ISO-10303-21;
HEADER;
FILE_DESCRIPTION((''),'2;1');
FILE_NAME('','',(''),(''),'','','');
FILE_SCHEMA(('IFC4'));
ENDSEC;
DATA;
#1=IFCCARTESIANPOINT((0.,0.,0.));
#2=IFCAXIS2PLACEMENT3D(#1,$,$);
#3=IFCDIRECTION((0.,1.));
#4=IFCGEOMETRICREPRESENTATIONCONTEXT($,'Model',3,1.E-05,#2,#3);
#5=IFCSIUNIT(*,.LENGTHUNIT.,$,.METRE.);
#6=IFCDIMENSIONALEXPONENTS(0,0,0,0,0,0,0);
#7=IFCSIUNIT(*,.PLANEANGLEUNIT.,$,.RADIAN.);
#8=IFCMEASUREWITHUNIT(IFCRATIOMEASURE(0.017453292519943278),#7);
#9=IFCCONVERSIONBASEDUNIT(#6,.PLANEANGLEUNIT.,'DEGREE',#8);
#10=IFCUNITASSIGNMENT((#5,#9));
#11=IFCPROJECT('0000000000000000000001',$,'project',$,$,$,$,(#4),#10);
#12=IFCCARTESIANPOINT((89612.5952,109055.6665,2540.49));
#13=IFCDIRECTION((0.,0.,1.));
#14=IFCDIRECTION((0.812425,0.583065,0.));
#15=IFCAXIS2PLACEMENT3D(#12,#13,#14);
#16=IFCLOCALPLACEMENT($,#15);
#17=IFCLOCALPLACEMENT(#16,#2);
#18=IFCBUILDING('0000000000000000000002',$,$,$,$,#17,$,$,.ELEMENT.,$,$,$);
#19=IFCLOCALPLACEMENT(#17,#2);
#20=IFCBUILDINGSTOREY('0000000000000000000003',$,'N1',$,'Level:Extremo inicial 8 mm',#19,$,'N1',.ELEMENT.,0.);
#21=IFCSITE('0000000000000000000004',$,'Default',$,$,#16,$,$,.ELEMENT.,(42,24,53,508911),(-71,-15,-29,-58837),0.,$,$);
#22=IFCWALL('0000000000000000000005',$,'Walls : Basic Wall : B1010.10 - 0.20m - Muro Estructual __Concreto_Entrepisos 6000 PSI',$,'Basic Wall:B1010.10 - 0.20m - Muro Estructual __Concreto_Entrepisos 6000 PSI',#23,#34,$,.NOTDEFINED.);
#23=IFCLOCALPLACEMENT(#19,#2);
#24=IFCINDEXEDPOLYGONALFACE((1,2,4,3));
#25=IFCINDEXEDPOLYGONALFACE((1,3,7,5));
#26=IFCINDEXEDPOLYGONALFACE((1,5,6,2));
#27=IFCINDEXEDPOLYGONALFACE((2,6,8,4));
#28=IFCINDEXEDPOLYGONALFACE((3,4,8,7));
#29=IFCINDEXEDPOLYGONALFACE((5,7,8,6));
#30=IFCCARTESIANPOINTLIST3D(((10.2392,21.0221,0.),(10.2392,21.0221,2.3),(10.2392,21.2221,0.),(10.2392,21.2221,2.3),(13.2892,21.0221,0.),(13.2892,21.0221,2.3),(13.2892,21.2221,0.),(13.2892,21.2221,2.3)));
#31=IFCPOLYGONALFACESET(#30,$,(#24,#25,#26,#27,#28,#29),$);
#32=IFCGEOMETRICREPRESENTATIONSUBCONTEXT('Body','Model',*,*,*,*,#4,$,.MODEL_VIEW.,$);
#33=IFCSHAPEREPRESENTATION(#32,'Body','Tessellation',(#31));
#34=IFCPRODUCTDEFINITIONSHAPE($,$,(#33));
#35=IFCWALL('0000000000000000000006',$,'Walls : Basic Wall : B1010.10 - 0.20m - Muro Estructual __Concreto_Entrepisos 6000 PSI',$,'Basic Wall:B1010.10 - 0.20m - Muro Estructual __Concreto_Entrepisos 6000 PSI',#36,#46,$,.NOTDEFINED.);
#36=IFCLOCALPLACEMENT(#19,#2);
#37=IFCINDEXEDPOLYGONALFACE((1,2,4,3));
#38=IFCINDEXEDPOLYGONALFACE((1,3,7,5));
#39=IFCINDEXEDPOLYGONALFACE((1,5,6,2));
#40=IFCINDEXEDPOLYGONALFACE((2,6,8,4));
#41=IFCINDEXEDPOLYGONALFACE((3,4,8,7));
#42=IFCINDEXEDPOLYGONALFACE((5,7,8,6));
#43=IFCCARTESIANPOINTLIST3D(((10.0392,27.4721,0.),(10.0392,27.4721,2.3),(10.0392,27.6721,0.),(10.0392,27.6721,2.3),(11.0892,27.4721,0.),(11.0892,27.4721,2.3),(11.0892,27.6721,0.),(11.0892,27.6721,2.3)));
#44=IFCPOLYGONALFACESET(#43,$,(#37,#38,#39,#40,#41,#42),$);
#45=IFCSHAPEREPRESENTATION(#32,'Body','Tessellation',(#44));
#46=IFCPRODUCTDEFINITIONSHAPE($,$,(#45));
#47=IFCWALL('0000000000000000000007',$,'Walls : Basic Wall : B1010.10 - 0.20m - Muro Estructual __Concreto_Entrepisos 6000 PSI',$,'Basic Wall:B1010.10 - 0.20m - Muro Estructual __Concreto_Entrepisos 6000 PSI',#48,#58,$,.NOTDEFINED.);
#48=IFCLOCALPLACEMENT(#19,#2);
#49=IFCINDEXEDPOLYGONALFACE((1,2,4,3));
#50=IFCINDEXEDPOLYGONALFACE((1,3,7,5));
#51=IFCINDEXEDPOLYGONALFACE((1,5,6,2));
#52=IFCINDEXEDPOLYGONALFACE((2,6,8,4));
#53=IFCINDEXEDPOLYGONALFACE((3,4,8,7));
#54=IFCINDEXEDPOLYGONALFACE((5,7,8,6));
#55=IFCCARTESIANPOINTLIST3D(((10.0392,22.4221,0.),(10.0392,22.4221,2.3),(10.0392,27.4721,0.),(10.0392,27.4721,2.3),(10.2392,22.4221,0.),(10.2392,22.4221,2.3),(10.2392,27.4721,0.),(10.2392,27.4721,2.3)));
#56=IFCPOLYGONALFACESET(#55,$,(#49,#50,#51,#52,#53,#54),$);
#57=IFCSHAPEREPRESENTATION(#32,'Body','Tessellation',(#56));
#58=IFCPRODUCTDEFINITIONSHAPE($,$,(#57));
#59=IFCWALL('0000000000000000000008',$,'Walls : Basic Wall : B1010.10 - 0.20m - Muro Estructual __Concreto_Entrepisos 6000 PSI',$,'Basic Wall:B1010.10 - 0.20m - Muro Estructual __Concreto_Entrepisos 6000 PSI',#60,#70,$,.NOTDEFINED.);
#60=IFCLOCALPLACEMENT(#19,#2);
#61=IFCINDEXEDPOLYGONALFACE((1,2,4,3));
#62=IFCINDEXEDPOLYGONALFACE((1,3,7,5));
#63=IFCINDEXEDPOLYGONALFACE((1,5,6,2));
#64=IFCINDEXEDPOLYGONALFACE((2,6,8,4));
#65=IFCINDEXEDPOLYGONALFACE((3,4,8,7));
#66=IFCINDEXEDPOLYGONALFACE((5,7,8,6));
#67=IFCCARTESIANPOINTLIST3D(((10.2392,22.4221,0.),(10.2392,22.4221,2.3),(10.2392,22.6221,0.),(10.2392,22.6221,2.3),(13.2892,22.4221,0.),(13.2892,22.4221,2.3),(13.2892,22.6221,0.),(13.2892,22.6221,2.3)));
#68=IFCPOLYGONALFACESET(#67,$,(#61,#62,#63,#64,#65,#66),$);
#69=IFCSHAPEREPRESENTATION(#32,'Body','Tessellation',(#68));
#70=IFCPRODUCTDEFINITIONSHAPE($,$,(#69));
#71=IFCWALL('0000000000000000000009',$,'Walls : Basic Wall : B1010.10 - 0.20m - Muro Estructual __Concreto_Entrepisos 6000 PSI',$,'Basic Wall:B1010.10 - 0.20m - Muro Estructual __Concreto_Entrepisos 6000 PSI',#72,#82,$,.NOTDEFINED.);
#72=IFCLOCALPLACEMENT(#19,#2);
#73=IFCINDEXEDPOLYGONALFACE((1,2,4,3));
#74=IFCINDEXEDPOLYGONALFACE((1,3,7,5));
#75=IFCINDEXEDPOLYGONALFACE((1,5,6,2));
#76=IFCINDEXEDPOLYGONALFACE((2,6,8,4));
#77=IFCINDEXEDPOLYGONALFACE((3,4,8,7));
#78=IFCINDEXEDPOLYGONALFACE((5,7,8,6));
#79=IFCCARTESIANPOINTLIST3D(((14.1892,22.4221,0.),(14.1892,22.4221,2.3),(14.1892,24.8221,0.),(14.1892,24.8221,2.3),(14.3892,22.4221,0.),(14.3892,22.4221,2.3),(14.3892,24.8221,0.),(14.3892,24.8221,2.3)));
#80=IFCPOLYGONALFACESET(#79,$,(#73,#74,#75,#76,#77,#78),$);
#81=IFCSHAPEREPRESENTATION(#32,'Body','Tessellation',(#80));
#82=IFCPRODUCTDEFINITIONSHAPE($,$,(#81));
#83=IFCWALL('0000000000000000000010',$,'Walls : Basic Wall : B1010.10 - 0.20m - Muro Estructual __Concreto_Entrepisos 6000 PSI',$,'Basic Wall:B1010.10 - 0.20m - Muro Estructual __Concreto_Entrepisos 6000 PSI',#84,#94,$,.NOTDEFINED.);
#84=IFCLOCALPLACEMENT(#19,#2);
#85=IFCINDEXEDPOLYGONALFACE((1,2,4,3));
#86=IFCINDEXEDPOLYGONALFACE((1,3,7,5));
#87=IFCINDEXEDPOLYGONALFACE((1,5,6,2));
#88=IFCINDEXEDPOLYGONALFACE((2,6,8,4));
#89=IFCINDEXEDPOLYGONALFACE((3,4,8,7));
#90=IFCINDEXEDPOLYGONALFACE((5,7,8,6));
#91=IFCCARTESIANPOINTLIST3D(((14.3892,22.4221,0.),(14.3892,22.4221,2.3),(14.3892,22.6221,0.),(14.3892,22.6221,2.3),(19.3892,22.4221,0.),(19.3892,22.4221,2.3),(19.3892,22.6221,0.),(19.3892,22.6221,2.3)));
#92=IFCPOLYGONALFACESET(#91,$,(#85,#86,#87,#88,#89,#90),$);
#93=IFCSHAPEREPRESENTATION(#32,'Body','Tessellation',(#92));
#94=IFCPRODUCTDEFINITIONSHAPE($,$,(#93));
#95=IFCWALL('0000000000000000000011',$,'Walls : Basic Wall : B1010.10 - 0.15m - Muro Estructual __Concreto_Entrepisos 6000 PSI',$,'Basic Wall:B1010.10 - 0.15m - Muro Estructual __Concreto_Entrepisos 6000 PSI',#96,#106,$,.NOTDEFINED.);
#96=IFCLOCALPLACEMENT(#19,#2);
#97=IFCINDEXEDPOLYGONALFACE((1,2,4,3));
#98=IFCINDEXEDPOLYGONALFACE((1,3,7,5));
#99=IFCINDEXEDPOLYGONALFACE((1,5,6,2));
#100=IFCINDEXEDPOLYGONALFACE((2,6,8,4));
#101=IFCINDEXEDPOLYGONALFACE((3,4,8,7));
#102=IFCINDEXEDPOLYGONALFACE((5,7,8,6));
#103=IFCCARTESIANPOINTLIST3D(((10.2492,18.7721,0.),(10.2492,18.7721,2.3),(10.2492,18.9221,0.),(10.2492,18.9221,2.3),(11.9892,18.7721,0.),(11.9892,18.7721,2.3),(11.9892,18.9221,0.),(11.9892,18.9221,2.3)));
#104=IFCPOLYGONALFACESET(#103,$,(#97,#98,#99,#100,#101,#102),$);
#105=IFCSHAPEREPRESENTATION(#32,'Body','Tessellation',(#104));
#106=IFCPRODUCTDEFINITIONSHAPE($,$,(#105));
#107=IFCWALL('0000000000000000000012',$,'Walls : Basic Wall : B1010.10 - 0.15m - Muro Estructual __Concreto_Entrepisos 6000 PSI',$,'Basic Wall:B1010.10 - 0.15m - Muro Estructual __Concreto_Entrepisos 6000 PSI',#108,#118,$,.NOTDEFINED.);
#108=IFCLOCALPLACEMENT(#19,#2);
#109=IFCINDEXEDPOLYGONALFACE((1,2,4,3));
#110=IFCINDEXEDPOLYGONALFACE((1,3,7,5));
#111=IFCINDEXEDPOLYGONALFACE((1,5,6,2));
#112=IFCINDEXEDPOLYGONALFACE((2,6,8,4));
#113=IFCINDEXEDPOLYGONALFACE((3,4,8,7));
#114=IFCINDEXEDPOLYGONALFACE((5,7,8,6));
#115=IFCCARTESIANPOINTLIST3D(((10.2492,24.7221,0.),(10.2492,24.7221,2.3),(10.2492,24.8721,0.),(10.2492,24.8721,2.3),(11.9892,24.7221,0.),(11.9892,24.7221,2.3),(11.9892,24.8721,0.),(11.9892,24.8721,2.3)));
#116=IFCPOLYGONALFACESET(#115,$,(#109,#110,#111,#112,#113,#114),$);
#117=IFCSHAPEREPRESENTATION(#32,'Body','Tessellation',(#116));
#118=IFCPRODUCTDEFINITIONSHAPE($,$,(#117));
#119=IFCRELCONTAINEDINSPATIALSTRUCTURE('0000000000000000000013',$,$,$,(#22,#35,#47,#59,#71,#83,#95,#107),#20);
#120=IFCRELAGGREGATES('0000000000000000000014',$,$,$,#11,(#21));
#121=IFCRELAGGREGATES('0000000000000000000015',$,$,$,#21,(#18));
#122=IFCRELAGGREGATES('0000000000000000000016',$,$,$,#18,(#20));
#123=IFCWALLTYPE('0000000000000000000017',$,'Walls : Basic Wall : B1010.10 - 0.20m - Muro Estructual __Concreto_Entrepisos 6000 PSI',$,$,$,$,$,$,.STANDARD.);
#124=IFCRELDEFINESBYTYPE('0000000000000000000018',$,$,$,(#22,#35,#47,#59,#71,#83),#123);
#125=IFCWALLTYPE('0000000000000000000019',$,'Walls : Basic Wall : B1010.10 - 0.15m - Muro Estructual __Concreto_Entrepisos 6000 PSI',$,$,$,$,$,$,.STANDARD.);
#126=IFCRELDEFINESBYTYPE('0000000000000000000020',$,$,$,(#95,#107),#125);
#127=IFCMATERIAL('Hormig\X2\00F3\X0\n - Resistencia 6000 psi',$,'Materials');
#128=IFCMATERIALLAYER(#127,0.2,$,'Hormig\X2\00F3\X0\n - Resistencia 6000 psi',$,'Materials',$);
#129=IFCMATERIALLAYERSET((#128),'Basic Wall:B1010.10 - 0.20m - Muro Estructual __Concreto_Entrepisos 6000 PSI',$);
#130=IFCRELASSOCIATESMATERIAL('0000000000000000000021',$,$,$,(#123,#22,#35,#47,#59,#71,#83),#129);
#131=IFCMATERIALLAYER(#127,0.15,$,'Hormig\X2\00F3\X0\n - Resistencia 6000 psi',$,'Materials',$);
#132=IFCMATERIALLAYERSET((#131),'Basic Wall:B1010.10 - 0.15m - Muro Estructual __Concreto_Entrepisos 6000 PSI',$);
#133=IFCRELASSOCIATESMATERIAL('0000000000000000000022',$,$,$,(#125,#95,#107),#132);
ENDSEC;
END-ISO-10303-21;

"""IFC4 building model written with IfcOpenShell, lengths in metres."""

from ifc_helpers import new_model, entity, si_unit, converted_unit, direction, frame, frame_2d, origin, place, context, subcontext, project, spatial, rectangle, extrude, material, layer, layer_set, layer_usage, type_object, element, save


model = new_model("IFC4")

# Units and contexts
model_context = context("Model", 3, precision=1e-05, world=origin(), true_north=direction((0.0, 1.0)))
body_context = subcontext(model_context, "Body", "Model", "MODEL_VIEW")
ifc_project = project(units=[si_unit("LENGTHUNIT", "METRE"), converted_unit("PLANEANGLEUNIT", "DEGREE", entity("IfcRatioMeasure", 0.017453292519943278), si_unit("PLANEANGLEUNIT", "RADIAN"), dimensions=[0, 0, 0, 0, 0, 0, 0])], contexts=[model_context])

# Site, building, storey
site_placement = place(None, frame((89612.5952, 109055.6665, 2540.49), z_axis=(0.0, 0.0, 1.0), x_axis=(0.812425, 0.583065, 0.0)))
site = spatial("IfcSite", under=ifc_project, at=site_placement, Name="Default", CompositionType="ELEMENT", RefLatitude=(42, 24, 53, 508911), RefLongitude=(-71, -15, -29, -58837), RefElevation=0.0)
building_placement = place(site_placement, origin())
building = spatial("IfcBuilding", under=site, at=building_placement, CompositionType="ELEMENT")
storey_placement = place(building_placement, origin())
storey = spatial("IfcBuildingStorey", under=building, at=storey_placement, Name="N1", ObjectType="Level:Extremo inicial 8 mm", LongName="N1", CompositionType="ELEMENT", Elevation=0.0)

# Walls
ifc_material_1 = material(Name="Hormigón - Resistencia 6000 psi", Category="Materials")
ifc_layer_1 = layer(ifc_material_1, 0.2, Name="Hormigón - Resistencia 6000 psi", Category="Materials")
ifc_layer_set_1 = layer_set([ifc_layer_1], Name="Basic Wall:B1010.10 - 0.20m - Muro Estructual __Concreto_Entrepisos 6000 PSI")
ifc_layer_usage_1 = layer_usage(ifc_layer_set_1, "AXIS2", "NEGATIVE", 0.1)
wall_type_1 = type_object("IfcWallType", Name="Walls : Basic Wall : B1010.10 - 0.20m - Muro Estructual __Concreto_Entrepisos 6000 PSI", PredefinedType="STANDARD", material=ifc_layer_set_1)
wall_1_placement = place(storey_placement, frame((10.2392, 21.1221, 0.0)))
element("IfcWall", 1, at=wall_1_placement, inside=storey, type_object=wall_type_1, material=ifc_layer_usage_1, Name="Walls : Basic Wall : B1010.10 - 0.20m - Muro Estructual __Concreto_Entrepisos 6000 PSI", ObjectType="Basic Wall:B1010.10 - 0.20m - Muro Estructual __Concreto_Entrepisos 6000 PSI", PredefinedType="NOTDEFINED", context=body_context, shape_type="SweptSolid", body=[
    extrude(rectangle(XDim=3.05, YDim=0.2, at=frame_2d((1.525, 0.0), x_axis=(-1.0, 0.0))), origin(), (0.0, 0.0, 1.0), 2.3),
])
ifc_layer_usage_2 = layer_usage(ifc_layer_set_1, "AXIS2", "POSITIVE", -0.1)
wall_2_placement = place(storey_placement, frame((11.0892, 27.5721, 0.0), z_axis=(0.0, 0.0, 1.0), x_axis=(-1.0, 0.0, 0.0)))
element("IfcWall", 2, at=wall_2_placement, inside=storey, type_object=wall_type_1, material=ifc_layer_usage_2, Name="Walls : Basic Wall : B1010.10 - 0.20m - Muro Estructual __Concreto_Entrepisos 6000 PSI", ObjectType="Basic Wall:B1010.10 - 0.20m - Muro Estructual __Concreto_Entrepisos 6000 PSI", PredefinedType="NOTDEFINED", context=body_context, shape_type="SweptSolid", body=[
    extrude(rectangle(XDim=1.05, YDim=0.2, at=frame_2d((0.525, 0.0), x_axis=(-1.0, 0.0))), origin(), (0.0, 0.0, 1.0), 2.3),
])
ifc_layer_usage_3 = layer_usage(ifc_layer_set_1, "AXIS2", "POSITIVE", -0.1)
wall_3_placement = place(storey_placement, frame((10.1392, 27.4721, 0.0), z_axis=(0.0, 0.0, 1.0), x_axis=(0.0, -1.0, 0.0)))
element("IfcWall", 3, at=wall_3_placement, inside=storey, type_object=wall_type_1, material=ifc_layer_usage_3, Name="Walls : Basic Wall : B1010.10 - 0.20m - Muro Estructual __Concreto_Entrepisos 6000 PSI", ObjectType="Basic Wall:B1010.10 - 0.20m - Muro Estructual __Concreto_Entrepisos 6000 PSI", PredefinedType="NOTDEFINED", context=body_context, shape_type="SweptSolid", body=[
    extrude(rectangle(XDim=5.05, YDim=0.2, at=frame_2d((2.525, 0.0), x_axis=(-1.0, 0.0))), origin(), (0.0, 0.0, 1.0), 2.3),
])
ifc_layer_usage_4 = layer_usage(ifc_layer_set_1, "AXIS2", "POSITIVE", -0.1)
wall_4_placement = place(storey_placement, frame((10.2392, 22.5221, 0.0)))
element("IfcWall", 4, at=wall_4_placement, inside=storey, type_object=wall_type_1, material=ifc_layer_usage_4, Name="Walls : Basic Wall : B1010.10 - 0.20m - Muro Estructual __Concreto_Entrepisos 6000 PSI", ObjectType="Basic Wall:B1010.10 - 0.20m - Muro Estructual __Concreto_Entrepisos 6000 PSI", PredefinedType="NOTDEFINED", context=body_context, shape_type="SweptSolid", body=[
    extrude(rectangle(XDim=3.05, YDim=0.2, at=frame_2d((1.525, 0.0), x_axis=(-1.0, 0.0))), origin(), (0.0, 0.0, 1.0), 2.3),
])
ifc_layer_usage_5 = layer_usage(ifc_layer_set_1, "AXIS2", "POSITIVE", -0.1)
wall_5_placement = place(storey_placement, frame((14.2892, 24.8221, 0.0), z_axis=(0.0, 0.0, 1.0), x_axis=(0.0, -1.0, 0.0)))
element("IfcWall", 5, at=wall_5_placement, inside=storey, type_object=wall_type_1, material=ifc_layer_usage_5, Name="Walls : Basic Wall : B1010.10 - 0.20m - Muro Estructual __Concreto_Entrepisos 6000 PSI", ObjectType="Basic Wall:B1010.10 - 0.20m - Muro Estructual __Concreto_Entrepisos 6000 PSI", PredefinedType="NOTDEFINED", context=body_context, shape_type="SweptSolid", body=[
    extrude(rectangle(XDim=2.4, YDim=0.2, at=frame_2d((1.2, 0.0), x_axis=(-1.0, 0.0))), origin(), (0.0, 0.0, 1.0), 2.3),
])
ifc_layer_usage_6 = layer_usage(ifc_layer_set_1, "AXIS2", "POSITIVE", -0.1)
wall_6_placement = place(storey_placement, frame((14.3892, 22.5221, 0.0)))
element("IfcWall", 6, at=wall_6_placement, inside=storey, type_object=wall_type_1, material=ifc_layer_usage_6, Name="Walls : Basic Wall : B1010.10 - 0.20m - Muro Estructual __Concreto_Entrepisos 6000 PSI", ObjectType="Basic Wall:B1010.10 - 0.20m - Muro Estructual __Concreto_Entrepisos 6000 PSI", PredefinedType="NOTDEFINED", context=body_context, shape_type="SweptSolid", body=[
    extrude(rectangle(XDim=5.0, YDim=0.2, at=frame_2d((2.5, 0.0), x_axis=(-1.0, 0.0))), origin(), (0.0, 0.0, 1.0), 2.3),
])
ifc_layer_2 = layer(ifc_material_1, 0.15, Name="Hormigón - Resistencia 6000 psi", Category="Materials")
ifc_layer_set_2 = layer_set([ifc_layer_2], Name="Basic Wall:B1010.10 - 0.15m - Muro Estructual __Concreto_Entrepisos 6000 PSI")
ifc_layer_usage_7 = layer_usage(ifc_layer_set_2, "AXIS2", "NEGATIVE", 0.075)
wall_type_2 = type_object("IfcWallType", Name="Walls : Basic Wall : B1010.10 - 0.15m - Muro Estructual __Concreto_Entrepisos 6000 PSI", PredefinedType="STANDARD", material=ifc_layer_set_2)
wall_7_placement = place(storey_placement, frame((11.9892, 18.8471, 0.0), z_axis=(0.0, 0.0, 1.0), x_axis=(-1.0, 0.0, 0.0)))
element("IfcWall", 7, at=wall_7_placement, inside=storey, type_object=wall_type_2, material=ifc_layer_usage_7, Name="Walls : Basic Wall : B1010.10 - 0.15m - Muro Estructual __Concreto_Entrepisos 6000 PSI", ObjectType="Basic Wall:B1010.10 - 0.15m - Muro Estructual __Concreto_Entrepisos 6000 PSI", PredefinedType="NOTDEFINED", context=body_context, shape_type="SweptSolid", body=[
    extrude(rectangle(XDim=1.74, YDim=0.15, at=frame_2d((0.87, 0.0), x_axis=(-1.0, 0.0))), origin(), (0.0, 0.0, 1.0), 2.3),
])
ifc_layer_usage_8 = layer_usage(ifc_layer_set_2, "AXIS2", "POSITIVE", -0.075)
wall_8_placement = place(storey_placement, frame((11.9892, 24.7971, 0.0), z_axis=(0.0, 0.0, 1.0), x_axis=(-1.0, 0.0, 0.0)))
element("IfcWall", 8, at=wall_8_placement, inside=storey, type_object=wall_type_2, material=ifc_layer_usage_8, Name="Walls : Basic Wall : B1010.10 - 0.15m - Muro Estructual __Concreto_Entrepisos 6000 PSI", ObjectType="Basic Wall:B1010.10 - 0.15m - Muro Estructual __Concreto_Entrepisos 6000 PSI", PredefinedType="NOTDEFINED", context=body_context, shape_type="SweptSolid", body=[
    extrude(rectangle(XDim=1.74, YDim=0.15, at=frame_2d((0.87, 0.0), x_axis=(-1.0, 0.0))), origin(), (0.0, 0.0, 1.0), 2.3),
])

save(model, "model.ifc")
